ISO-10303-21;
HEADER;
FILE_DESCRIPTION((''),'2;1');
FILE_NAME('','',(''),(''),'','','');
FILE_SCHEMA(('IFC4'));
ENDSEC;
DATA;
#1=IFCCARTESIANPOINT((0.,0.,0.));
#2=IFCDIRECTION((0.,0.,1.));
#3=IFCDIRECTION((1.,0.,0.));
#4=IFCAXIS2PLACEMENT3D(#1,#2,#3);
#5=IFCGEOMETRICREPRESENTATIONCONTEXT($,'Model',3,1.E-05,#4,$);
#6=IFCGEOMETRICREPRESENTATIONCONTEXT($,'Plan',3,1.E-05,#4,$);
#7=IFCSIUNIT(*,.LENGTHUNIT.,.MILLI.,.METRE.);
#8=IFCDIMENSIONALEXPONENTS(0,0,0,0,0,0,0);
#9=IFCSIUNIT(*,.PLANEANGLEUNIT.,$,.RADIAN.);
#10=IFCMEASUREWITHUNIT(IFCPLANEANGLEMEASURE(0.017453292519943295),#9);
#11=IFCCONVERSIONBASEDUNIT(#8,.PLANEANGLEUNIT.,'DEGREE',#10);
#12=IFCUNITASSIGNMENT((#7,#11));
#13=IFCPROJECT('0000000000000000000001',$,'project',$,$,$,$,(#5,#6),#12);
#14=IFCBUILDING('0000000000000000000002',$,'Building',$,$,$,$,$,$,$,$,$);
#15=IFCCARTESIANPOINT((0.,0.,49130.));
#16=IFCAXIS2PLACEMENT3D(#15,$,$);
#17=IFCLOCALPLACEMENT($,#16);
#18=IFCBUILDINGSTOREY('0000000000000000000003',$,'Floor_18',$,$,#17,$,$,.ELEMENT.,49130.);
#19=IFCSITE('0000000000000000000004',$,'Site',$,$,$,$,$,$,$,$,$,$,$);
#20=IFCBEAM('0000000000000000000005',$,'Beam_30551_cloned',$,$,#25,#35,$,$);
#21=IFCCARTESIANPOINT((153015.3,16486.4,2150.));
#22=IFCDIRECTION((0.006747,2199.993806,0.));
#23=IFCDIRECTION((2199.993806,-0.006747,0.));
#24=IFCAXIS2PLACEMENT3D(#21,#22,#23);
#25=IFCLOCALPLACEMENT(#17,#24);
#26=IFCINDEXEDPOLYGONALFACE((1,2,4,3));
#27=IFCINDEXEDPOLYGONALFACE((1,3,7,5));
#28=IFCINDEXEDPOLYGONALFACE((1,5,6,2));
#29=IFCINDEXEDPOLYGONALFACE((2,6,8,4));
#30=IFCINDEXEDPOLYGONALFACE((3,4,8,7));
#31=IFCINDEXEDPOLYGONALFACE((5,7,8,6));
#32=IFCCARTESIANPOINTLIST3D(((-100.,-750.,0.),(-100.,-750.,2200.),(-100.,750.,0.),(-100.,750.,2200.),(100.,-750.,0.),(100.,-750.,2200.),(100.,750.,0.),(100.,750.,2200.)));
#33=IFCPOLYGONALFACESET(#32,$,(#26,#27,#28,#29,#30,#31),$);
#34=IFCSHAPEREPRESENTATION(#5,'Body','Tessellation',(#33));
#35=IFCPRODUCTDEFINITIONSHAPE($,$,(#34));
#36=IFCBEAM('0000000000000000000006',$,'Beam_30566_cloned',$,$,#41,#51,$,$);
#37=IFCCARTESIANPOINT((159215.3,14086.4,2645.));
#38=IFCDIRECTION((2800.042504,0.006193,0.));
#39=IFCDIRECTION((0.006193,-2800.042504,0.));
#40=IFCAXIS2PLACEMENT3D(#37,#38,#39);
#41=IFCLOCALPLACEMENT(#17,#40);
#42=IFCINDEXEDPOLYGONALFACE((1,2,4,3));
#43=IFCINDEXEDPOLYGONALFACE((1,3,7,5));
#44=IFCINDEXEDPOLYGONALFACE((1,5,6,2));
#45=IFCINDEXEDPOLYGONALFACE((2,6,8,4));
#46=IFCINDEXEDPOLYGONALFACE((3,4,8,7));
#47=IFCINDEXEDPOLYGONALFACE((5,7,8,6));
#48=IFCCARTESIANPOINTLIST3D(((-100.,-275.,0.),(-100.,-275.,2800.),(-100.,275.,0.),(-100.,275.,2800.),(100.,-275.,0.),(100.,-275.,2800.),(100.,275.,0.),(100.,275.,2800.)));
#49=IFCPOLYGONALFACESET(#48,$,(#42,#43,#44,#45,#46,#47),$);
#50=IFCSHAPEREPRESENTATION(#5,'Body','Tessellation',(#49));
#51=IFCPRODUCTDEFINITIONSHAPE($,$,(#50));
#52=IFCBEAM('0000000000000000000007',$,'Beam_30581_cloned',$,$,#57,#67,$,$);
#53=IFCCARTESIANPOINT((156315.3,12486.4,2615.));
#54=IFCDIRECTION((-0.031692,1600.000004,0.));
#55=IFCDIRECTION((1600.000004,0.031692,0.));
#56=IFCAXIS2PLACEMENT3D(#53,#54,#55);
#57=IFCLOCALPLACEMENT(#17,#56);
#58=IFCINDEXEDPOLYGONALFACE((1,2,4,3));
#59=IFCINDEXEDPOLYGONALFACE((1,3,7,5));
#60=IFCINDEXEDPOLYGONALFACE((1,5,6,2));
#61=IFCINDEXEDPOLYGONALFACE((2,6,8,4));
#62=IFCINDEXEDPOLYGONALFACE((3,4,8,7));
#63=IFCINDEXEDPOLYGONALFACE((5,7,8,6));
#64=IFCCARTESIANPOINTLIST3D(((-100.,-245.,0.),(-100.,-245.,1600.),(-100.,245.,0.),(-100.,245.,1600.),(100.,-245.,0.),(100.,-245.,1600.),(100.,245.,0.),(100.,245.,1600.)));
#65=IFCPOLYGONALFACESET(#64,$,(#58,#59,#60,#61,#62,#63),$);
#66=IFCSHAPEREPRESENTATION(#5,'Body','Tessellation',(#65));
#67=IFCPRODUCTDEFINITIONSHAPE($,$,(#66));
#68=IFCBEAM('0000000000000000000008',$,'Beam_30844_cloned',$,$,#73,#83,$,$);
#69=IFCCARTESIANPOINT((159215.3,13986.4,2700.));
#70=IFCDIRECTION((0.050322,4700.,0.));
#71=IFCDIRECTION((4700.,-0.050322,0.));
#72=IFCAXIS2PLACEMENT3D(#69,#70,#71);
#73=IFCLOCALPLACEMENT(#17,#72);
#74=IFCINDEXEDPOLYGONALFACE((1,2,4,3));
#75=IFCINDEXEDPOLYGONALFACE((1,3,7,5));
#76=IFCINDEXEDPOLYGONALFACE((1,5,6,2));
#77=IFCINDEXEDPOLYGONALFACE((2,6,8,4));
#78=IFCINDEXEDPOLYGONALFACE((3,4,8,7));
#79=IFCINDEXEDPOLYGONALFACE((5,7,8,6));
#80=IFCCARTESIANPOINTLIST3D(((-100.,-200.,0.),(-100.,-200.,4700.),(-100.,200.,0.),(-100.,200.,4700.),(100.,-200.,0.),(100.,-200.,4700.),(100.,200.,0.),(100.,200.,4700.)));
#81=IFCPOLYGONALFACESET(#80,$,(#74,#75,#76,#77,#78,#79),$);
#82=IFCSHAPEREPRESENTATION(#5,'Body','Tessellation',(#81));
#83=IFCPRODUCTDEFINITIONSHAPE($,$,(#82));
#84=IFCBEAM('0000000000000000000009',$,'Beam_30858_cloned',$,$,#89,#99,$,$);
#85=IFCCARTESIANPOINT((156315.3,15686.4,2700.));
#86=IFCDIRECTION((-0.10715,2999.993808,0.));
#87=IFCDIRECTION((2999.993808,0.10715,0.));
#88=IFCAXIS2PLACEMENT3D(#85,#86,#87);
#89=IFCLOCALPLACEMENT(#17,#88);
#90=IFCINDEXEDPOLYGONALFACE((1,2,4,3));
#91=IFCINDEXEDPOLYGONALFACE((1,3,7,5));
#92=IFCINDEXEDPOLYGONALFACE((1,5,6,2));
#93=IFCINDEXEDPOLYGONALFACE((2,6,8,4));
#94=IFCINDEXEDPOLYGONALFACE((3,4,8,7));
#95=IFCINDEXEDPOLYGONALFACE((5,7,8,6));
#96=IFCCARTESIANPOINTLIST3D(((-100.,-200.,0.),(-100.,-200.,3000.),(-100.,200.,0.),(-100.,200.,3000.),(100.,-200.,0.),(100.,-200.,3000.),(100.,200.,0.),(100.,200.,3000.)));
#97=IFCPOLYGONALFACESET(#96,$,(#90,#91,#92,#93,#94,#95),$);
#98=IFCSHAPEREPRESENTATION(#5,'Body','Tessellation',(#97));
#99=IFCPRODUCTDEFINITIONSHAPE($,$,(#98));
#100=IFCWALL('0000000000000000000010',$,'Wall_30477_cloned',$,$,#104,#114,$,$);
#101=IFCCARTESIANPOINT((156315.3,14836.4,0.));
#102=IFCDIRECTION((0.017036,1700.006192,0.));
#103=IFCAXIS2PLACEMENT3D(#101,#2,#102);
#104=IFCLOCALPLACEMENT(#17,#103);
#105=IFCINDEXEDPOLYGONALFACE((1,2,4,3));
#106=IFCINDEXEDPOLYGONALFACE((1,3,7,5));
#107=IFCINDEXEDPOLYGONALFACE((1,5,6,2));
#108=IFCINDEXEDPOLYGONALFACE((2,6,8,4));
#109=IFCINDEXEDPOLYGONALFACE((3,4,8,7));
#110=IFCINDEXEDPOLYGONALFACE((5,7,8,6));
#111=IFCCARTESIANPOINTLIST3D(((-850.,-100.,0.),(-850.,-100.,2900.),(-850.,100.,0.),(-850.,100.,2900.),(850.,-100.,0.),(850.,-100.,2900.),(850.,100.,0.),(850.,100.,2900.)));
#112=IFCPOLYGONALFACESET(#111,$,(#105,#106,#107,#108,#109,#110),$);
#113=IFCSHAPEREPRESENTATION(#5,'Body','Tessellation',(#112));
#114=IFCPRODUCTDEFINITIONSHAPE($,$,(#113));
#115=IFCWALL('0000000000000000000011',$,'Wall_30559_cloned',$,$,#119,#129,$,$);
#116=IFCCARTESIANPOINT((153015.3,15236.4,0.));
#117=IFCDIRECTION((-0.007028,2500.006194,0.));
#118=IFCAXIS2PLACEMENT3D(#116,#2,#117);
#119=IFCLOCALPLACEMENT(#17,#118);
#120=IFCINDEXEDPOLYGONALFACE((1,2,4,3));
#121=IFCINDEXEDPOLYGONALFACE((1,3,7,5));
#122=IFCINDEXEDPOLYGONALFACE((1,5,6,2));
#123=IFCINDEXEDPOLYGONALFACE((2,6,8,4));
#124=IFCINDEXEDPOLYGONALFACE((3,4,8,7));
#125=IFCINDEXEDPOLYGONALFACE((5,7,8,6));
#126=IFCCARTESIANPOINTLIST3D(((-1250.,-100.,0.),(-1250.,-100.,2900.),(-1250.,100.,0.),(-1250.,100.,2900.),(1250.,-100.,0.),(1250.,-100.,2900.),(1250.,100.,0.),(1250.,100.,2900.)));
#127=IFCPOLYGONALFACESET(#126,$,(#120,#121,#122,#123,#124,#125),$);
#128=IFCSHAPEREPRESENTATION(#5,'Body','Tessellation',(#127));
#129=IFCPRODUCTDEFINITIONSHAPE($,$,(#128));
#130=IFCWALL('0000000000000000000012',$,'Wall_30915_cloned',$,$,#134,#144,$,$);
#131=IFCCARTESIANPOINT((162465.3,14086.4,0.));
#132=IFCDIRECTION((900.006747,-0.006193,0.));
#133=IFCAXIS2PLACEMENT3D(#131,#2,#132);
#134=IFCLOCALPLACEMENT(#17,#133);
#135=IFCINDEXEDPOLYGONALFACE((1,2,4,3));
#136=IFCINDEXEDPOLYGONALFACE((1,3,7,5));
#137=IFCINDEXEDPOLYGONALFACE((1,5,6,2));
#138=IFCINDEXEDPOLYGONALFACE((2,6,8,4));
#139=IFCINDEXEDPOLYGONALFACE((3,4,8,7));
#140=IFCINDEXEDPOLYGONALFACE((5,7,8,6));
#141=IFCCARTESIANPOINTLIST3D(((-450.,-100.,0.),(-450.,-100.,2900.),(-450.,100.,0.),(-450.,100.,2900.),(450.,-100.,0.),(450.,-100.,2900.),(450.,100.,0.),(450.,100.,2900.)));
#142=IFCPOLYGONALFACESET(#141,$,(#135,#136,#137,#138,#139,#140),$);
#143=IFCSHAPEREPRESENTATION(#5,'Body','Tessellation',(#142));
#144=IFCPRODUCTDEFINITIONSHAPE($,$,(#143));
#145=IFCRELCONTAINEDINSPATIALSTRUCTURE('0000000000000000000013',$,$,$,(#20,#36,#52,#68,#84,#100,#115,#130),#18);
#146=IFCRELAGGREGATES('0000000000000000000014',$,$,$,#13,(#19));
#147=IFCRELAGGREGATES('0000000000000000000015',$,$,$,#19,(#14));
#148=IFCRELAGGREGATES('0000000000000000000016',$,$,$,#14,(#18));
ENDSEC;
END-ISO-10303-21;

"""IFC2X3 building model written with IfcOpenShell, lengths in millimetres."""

from ifc_helpers import new_model, entity, si_unit, converted_unit, frame, origin_with_axes, origin_2d, place, context, project, spatial, rectangle, extrude, source, transform, mapped, element, save


model = new_model("IFC2X3")

# Units and contexts
model_context = context("Model", 3, precision=1e-05, world=origin_with_axes())
plan_context = context("Plan", 3, precision=1e-05, world=origin_with_axes())
ifc_project = project(units=[si_unit("LENGTHUNIT", "METRE", prefix="MILLI"), converted_unit("PLANEANGLEUNIT", "DEGREE", entity("IfcPlaneAngleMeasure", 0.017453292519943295), si_unit("PLANEANGLEUNIT", "RADIAN"), dimensions=[0, 0, 0, 0, 0, 0, 0])], contexts=[model_context, plan_context])

# Site, building, storey
site = spatial("IfcSite", under=ifc_project, Name="Site")
building = spatial("IfcBuilding", under=site, Name="Building")
storey_placement = place(None, frame((0.0, 0.0, 49130.0)))
storey = spatial("IfcBuildingStorey", under=building, at=storey_placement, Name="Floor_18", CompositionType="ELEMENT", Elevation=49130.0)

# Beams
shared_shape_1 = source(origin_with_axes(), model_context, "Body", "SweptSolid", [
    extrude(rectangle(XDim=200.0, YDim=1500.0, at=origin_2d()), origin_with_axes(), (0.0, 0.0, 1.0), 2200.0),
])
beam_1_placement = place(storey_placement, frame((153015.3, 16486.4, 2150.0), z_axis=(0.006747, 2199.993806, 0.0), x_axis=(2199.993806, -0.006747, 0.0)))
element("IfcBeam", 1, at=beam_1_placement, inside=storey, Name="Beam_30551_cloned", context=model_context, shape_type="MappedRepresentation", body=[
    mapped(shared_shape_1, transform((0.0, 0.0, 0.0), x_axis=(1.0, 0.0, 0.0), y_axis=(0.0, 1.0, 0.0), z_axis=(0.0, 0.0, 1.0), scale=1.0)),
])
shared_shape_2 = source(origin_with_axes(), model_context, "Body", "SweptSolid", [
    extrude(rectangle(XDim=200.0, YDim=550.0, at=origin_2d()), origin_with_axes(), (0.0, 0.0, 1.0), 2800.0),
])
beam_2_placement = place(storey_placement, frame((159215.3, 14086.4, 2645.0), z_axis=(2800.042504, 0.006193, 0.0), x_axis=(0.006193, -2800.042504, 0.0)))
element("IfcBeam", 2, at=beam_2_placement, inside=storey, Name="Beam_30566_cloned", context=model_context, shape_type="MappedRepresentation", body=[
    mapped(shared_shape_2, transform((0.0, 0.0, 0.0), x_axis=(1.0, 0.0, 0.0), y_axis=(0.0, 1.0, 0.0), z_axis=(0.0, 0.0, 1.0), scale=1.0)),
])
shared_shape_3 = source(origin_with_axes(), model_context, "Body", "SweptSolid", [
    extrude(rectangle(XDim=200.0, YDim=490.0, at=origin_2d()), origin_with_axes(), (0.0, 0.0, 1.0), 1600.0),
])
beam_3_placement = place(storey_placement, frame((156315.3, 12486.4, 2615.0), z_axis=(-0.031692, 1600.000004, 0.0), x_axis=(1600.000004, 0.031692, 0.0)))
element("IfcBeam", 3, at=beam_3_placement, inside=storey, Name="Beam_30581_cloned", context=model_context, shape_type="MappedRepresentation", body=[
    mapped(shared_shape_3, transform((0.0, 0.0, 0.0), x_axis=(1.0, 0.0, 0.0), y_axis=(0.0, 1.0, 0.0), z_axis=(0.0, 0.0, 1.0), scale=1.0)),
])
shared_shape_4 = source(origin_with_axes(), model_context, "Body", "SweptSolid", [
    extrude(rectangle(XDim=200.0, YDim=400.0, at=origin_2d()), origin_with_axes(), (0.0, 0.0, 1.0), 4700.0),
])
beam_4_placement = place(storey_placement, frame((159215.3, 13986.4, 2700.0), z_axis=(0.050322, 4700.0, 0.0), x_axis=(4700.0, -0.050322, 0.0)))
element("IfcBeam", 4, at=beam_4_placement, inside=storey, Name="Beam_30844_cloned", context=model_context, shape_type="MappedRepresentation", body=[
    mapped(shared_shape_4, transform((0.0, 0.0, 0.0), x_axis=(1.0, 0.0, 0.0), y_axis=(0.0, 1.0, 0.0), z_axis=(0.0, 0.0, 1.0), scale=1.0)),
])
shared_shape_5 = source(origin_with_axes(), model_context, "Body", "SweptSolid", [
    extrude(rectangle(XDim=200.0, YDim=400.0, at=origin_2d()), origin_with_axes(), (0.0, 0.0, 1.0), 3000.0),
])
beam_5_placement = place(storey_placement, frame((156315.3, 15686.4, 2700.0), z_axis=(-0.10715, 2999.993808, 0.0), x_axis=(2999.993808, 0.10715, 0.0)))
element("IfcBeam", 5, at=beam_5_placement, inside=storey, Name="Beam_30858_cloned", context=model_context, shape_type="MappedRepresentation", body=[
    mapped(shared_shape_5, transform((0.0, 0.0, 0.0), x_axis=(1.0, 0.0, 0.0), y_axis=(0.0, 1.0, 0.0), z_axis=(0.0, 0.0, 1.0), scale=1.0)),
])

# Walls
shared_shape_6 = source(origin_with_axes(), model_context, "Body", "SweptSolid", [
    extrude(rectangle(XDim=1700.0, YDim=200.0, at=origin_2d()), origin_with_axes(), (0.0, 0.0, 1.0), 2900.0),
])
wall_1_placement = place(storey_placement, frame((156315.3, 14836.4, 0.0), z_axis=(0.0, 0.0, 1.0), x_axis=(0.017036, 1700.006192, 0.0)))
element("IfcWall", 6, at=wall_1_placement, inside=storey, Name="Wall_30477_cloned", context=model_context, shape_type="MappedRepresentation", body=[
    mapped(shared_shape_6, transform((0.0, 0.0, 0.0), x_axis=(1.0, 0.0, 0.0), y_axis=(0.0, 1.0, 0.0), z_axis=(0.0, 0.0, 1.0), scale=1.0)),
])
shared_shape_7 = source(origin_with_axes(), model_context, "Body", "SweptSolid", [
    extrude(rectangle(XDim=2500.0, YDim=200.0, at=origin_2d()), origin_with_axes(), (0.0, 0.0, 1.0), 2900.0),
])
wall_2_placement = place(storey_placement, frame((153015.3, 15236.4, 0.0), z_axis=(0.0, 0.0, 1.0), x_axis=(-0.007028, 2500.006194, 0.0)))
element("IfcWall", 7, at=wall_2_placement, inside=storey, Name="Wall_30559_cloned", context=model_context, shape_type="MappedRepresentation", body=[
    mapped(shared_shape_7, transform((0.0, 0.0, 0.0), x_axis=(1.0, 0.0, 0.0), y_axis=(0.0, 1.0, 0.0), z_axis=(0.0, 0.0, 1.0), scale=1.0)),
])
shared_shape_8 = source(origin_with_axes(), model_context, "Body", "SweptSolid", [
    extrude(rectangle(XDim=900.0, YDim=200.0, at=origin_2d()), origin_with_axes(), (0.0, 0.0, 1.0), 2900.0),
])
wall_3_placement = place(storey_placement, frame((162465.3, 14086.4, 0.0), z_axis=(0.0, 0.0, 1.0), x_axis=(900.006747, -0.006193, 0.0)))
element("IfcWall", 8, at=wall_3_placement, inside=storey, Name="Wall_30915_cloned", context=model_context, shape_type="MappedRepresentation", body=[
    mapped(shared_shape_8, transform((0.0, 0.0, 0.0), x_axis=(1.0, 0.0, 0.0), y_axis=(0.0, 1.0, 0.0), z_axis=(0.0, 0.0, 1.0), scale=1.0)),
])

save(model, "model.ifc")
